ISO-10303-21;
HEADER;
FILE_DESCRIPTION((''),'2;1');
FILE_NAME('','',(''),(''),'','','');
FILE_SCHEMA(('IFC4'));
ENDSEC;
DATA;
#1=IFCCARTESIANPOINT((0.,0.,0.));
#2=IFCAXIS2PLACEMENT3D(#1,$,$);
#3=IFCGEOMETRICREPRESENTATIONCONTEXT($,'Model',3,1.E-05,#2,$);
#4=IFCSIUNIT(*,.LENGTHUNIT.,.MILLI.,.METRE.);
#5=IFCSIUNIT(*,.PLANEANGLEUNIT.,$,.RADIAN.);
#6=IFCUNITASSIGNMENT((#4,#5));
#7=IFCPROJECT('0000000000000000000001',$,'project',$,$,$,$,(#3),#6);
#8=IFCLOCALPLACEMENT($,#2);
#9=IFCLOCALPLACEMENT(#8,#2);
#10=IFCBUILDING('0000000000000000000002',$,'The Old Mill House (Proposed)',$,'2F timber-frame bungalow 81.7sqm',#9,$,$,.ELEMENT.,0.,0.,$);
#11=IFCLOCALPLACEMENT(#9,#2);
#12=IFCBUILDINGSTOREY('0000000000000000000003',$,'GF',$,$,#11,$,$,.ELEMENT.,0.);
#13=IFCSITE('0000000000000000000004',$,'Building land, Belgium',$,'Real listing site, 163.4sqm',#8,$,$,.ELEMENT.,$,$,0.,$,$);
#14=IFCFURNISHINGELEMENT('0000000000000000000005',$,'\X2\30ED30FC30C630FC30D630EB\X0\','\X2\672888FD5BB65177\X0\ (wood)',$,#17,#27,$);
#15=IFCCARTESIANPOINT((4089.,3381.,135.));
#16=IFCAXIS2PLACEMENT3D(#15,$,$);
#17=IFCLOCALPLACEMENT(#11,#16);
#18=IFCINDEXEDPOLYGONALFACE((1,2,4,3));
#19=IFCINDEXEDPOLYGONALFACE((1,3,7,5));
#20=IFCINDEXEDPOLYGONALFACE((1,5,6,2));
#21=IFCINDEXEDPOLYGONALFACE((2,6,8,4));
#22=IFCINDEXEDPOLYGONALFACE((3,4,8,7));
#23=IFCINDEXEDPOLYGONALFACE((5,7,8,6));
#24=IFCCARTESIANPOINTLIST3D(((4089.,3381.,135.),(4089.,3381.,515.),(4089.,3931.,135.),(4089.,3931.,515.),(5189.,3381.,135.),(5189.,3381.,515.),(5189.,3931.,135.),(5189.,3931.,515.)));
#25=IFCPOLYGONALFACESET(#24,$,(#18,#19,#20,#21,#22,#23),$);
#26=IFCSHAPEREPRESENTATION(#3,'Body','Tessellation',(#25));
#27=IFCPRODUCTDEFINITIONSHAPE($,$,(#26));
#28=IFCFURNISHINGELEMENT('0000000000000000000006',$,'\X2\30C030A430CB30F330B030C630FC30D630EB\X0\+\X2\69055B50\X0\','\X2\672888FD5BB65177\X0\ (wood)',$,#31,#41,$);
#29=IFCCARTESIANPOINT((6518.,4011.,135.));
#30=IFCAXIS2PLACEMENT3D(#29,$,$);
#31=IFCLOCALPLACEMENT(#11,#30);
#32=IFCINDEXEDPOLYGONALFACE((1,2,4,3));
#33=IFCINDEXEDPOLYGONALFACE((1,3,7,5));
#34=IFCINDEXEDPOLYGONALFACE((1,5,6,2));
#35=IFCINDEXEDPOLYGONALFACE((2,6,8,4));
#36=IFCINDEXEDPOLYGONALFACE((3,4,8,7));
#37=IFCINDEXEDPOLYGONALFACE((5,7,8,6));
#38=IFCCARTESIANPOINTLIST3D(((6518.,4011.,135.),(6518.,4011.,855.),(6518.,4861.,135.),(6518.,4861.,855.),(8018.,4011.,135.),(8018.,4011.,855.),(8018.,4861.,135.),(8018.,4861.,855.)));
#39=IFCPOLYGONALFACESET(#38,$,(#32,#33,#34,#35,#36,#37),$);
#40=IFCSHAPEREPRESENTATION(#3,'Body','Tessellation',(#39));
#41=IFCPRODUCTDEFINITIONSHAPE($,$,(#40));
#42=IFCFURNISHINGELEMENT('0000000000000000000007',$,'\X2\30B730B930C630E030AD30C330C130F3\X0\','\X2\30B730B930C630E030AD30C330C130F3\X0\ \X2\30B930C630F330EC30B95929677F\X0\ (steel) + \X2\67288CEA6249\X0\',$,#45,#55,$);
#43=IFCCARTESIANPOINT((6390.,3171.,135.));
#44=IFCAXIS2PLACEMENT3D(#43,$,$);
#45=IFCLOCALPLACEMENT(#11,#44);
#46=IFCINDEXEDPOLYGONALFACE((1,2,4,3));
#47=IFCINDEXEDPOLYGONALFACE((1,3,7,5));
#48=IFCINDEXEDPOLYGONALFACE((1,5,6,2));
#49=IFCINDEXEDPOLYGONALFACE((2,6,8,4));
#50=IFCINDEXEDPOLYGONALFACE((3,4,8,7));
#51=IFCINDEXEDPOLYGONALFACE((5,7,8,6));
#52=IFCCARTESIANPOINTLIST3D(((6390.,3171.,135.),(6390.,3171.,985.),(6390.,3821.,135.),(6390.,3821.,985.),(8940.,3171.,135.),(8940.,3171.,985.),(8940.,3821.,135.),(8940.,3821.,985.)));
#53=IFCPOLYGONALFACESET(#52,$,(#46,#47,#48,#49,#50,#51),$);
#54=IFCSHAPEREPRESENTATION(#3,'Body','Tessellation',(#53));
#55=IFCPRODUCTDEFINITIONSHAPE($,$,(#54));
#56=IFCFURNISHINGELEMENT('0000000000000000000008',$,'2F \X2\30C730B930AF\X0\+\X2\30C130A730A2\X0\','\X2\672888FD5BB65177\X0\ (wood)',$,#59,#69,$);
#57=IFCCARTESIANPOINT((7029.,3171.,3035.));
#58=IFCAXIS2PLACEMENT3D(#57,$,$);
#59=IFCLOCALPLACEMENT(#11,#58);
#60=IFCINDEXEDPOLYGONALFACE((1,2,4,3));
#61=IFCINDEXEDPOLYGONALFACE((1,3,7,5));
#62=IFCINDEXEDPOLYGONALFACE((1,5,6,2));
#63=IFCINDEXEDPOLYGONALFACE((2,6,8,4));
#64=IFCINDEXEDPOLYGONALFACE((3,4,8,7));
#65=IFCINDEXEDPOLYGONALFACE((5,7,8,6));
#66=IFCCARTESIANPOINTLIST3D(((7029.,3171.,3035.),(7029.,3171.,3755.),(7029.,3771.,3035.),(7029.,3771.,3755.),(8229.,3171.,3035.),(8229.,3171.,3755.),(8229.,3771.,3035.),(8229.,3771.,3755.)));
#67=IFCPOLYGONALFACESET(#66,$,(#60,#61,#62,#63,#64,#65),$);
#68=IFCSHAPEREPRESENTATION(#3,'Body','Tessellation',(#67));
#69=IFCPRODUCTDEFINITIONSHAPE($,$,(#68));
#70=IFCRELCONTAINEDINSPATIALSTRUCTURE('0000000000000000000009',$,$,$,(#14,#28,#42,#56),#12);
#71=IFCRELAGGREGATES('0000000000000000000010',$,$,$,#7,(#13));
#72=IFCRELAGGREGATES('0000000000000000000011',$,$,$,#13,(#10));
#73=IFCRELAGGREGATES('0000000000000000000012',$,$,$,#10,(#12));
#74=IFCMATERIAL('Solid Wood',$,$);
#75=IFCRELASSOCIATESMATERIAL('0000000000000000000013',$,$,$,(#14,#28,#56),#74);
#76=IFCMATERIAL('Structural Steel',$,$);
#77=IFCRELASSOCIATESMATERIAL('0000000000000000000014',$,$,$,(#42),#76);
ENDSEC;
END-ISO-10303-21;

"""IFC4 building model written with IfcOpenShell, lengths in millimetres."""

from ifc_helpers import new_model, si_unit, frame, frame_2d, origin, place, context, project, spatial, rectangle, extrude, material, element, save


model = new_model("IFC4")

# Units and contexts
model_context = context("Model", 3, precision=1e-05, world=origin())
ifc_project = project(units=[si_unit("LENGTHUNIT", "METRE", prefix="MILLI"), si_unit("PLANEANGLEUNIT", "RADIAN")], contexts=[model_context])

# Site, building, storey
site_placement = place(None, origin())
site = spatial("IfcSite", under=ifc_project, at=site_placement, Name="Building land, Belgium", ObjectType="Real listing site, 163.4sqm", CompositionType="ELEMENT", RefElevation=0.0)
building_placement = place(site_placement, origin())
building = spatial("IfcBuilding", under=site, at=building_placement, Name="The Old Mill House (Proposed)", ObjectType="2F timber-frame bungalow 81.7sqm", CompositionType="ELEMENT", ElevationOfRefHeight=0.0, ElevationOfTerrain=0.0)
storey_placement = place(building_placement, origin())
storey = spatial("IfcBuildingStorey", under=building, at=storey_placement, Name="GF", CompositionType="ELEMENT", Elevation=0.0)

# Shared definitions
ifc_material_1 = material(Name="Solid Wood")

# Shared definitions
ifc_material_2 = material(Name="Structural Steel")

# Furnishing elements
furnishing_1_placement = place(storey_placement, frame((4089.0, 3381.0, 135.0)))
element("IfcFurnishingElement", 1, at=furnishing_1_placement, inside=storey, material=ifc_material_1, Name="ローテーブル", Description="木製家具 (wood)", context=model_context, shape_type="SweptSolid", body=[
    extrude(rectangle(XDim=1100.0, YDim=550.0, at=frame_2d((550.0, 275.0))), frame((4089.0, 3381.0, 135.0)), (0.0, 0.0, 1.0), 380.0),
])
furnishing_2_placement = place(storey_placement, frame((6518.0, 4011.0, 135.0)))
element("IfcFurnishingElement", 2, at=furnishing_2_placement, inside=storey, material=ifc_material_1, Name="ダイニングテーブル+椅子", Description="木製家具 (wood)", context=model_context, shape_type="SweptSolid", body=[
    extrude(rectangle(XDim=1500.0, YDim=850.0, at=frame_2d((750.0, 425.0))), frame((6518.0, 4011.0, 135.0)), (0.0, 0.0, 1.0), 720.0),
])
furnishing_3_placement = place(storey_placement, frame((6390.0, 3171.0, 135.0)))
element("IfcFurnishingElement", 3, at=furnishing_3_placement, inside=storey, material=ifc_material_2, Name="システムキッチン", Description="システムキッチン ステンレス天板 (steel) + 木質扉", context=model_context, shape_type="SweptSolid", body=[
    extrude(rectangle(XDim=2550.0, YDim=650.0, at=frame_2d((1275.0, 325.0))), frame((6390.0, 3171.0, 135.0)), (0.0, 0.0, 1.0), 850.0),
])
furnishing_4_placement = place(storey_placement, frame((7029.0, 3171.0, 3035.0)))
element("IfcFurnishingElement", 4, at=furnishing_4_placement, inside=storey, material=ifc_material_1, Name="2F デスク+チェア", Description="木製家具 (wood)", context=model_context, shape_type="SweptSolid", body=[
    extrude(rectangle(XDim=1200.0, YDim=600.0, at=frame_2d((600.0, 300.0))), frame((7029.0, 3171.0, 3035.0)), (0.0, 0.0, 1.0), 720.0),
])

save(model, "model.ifc")
